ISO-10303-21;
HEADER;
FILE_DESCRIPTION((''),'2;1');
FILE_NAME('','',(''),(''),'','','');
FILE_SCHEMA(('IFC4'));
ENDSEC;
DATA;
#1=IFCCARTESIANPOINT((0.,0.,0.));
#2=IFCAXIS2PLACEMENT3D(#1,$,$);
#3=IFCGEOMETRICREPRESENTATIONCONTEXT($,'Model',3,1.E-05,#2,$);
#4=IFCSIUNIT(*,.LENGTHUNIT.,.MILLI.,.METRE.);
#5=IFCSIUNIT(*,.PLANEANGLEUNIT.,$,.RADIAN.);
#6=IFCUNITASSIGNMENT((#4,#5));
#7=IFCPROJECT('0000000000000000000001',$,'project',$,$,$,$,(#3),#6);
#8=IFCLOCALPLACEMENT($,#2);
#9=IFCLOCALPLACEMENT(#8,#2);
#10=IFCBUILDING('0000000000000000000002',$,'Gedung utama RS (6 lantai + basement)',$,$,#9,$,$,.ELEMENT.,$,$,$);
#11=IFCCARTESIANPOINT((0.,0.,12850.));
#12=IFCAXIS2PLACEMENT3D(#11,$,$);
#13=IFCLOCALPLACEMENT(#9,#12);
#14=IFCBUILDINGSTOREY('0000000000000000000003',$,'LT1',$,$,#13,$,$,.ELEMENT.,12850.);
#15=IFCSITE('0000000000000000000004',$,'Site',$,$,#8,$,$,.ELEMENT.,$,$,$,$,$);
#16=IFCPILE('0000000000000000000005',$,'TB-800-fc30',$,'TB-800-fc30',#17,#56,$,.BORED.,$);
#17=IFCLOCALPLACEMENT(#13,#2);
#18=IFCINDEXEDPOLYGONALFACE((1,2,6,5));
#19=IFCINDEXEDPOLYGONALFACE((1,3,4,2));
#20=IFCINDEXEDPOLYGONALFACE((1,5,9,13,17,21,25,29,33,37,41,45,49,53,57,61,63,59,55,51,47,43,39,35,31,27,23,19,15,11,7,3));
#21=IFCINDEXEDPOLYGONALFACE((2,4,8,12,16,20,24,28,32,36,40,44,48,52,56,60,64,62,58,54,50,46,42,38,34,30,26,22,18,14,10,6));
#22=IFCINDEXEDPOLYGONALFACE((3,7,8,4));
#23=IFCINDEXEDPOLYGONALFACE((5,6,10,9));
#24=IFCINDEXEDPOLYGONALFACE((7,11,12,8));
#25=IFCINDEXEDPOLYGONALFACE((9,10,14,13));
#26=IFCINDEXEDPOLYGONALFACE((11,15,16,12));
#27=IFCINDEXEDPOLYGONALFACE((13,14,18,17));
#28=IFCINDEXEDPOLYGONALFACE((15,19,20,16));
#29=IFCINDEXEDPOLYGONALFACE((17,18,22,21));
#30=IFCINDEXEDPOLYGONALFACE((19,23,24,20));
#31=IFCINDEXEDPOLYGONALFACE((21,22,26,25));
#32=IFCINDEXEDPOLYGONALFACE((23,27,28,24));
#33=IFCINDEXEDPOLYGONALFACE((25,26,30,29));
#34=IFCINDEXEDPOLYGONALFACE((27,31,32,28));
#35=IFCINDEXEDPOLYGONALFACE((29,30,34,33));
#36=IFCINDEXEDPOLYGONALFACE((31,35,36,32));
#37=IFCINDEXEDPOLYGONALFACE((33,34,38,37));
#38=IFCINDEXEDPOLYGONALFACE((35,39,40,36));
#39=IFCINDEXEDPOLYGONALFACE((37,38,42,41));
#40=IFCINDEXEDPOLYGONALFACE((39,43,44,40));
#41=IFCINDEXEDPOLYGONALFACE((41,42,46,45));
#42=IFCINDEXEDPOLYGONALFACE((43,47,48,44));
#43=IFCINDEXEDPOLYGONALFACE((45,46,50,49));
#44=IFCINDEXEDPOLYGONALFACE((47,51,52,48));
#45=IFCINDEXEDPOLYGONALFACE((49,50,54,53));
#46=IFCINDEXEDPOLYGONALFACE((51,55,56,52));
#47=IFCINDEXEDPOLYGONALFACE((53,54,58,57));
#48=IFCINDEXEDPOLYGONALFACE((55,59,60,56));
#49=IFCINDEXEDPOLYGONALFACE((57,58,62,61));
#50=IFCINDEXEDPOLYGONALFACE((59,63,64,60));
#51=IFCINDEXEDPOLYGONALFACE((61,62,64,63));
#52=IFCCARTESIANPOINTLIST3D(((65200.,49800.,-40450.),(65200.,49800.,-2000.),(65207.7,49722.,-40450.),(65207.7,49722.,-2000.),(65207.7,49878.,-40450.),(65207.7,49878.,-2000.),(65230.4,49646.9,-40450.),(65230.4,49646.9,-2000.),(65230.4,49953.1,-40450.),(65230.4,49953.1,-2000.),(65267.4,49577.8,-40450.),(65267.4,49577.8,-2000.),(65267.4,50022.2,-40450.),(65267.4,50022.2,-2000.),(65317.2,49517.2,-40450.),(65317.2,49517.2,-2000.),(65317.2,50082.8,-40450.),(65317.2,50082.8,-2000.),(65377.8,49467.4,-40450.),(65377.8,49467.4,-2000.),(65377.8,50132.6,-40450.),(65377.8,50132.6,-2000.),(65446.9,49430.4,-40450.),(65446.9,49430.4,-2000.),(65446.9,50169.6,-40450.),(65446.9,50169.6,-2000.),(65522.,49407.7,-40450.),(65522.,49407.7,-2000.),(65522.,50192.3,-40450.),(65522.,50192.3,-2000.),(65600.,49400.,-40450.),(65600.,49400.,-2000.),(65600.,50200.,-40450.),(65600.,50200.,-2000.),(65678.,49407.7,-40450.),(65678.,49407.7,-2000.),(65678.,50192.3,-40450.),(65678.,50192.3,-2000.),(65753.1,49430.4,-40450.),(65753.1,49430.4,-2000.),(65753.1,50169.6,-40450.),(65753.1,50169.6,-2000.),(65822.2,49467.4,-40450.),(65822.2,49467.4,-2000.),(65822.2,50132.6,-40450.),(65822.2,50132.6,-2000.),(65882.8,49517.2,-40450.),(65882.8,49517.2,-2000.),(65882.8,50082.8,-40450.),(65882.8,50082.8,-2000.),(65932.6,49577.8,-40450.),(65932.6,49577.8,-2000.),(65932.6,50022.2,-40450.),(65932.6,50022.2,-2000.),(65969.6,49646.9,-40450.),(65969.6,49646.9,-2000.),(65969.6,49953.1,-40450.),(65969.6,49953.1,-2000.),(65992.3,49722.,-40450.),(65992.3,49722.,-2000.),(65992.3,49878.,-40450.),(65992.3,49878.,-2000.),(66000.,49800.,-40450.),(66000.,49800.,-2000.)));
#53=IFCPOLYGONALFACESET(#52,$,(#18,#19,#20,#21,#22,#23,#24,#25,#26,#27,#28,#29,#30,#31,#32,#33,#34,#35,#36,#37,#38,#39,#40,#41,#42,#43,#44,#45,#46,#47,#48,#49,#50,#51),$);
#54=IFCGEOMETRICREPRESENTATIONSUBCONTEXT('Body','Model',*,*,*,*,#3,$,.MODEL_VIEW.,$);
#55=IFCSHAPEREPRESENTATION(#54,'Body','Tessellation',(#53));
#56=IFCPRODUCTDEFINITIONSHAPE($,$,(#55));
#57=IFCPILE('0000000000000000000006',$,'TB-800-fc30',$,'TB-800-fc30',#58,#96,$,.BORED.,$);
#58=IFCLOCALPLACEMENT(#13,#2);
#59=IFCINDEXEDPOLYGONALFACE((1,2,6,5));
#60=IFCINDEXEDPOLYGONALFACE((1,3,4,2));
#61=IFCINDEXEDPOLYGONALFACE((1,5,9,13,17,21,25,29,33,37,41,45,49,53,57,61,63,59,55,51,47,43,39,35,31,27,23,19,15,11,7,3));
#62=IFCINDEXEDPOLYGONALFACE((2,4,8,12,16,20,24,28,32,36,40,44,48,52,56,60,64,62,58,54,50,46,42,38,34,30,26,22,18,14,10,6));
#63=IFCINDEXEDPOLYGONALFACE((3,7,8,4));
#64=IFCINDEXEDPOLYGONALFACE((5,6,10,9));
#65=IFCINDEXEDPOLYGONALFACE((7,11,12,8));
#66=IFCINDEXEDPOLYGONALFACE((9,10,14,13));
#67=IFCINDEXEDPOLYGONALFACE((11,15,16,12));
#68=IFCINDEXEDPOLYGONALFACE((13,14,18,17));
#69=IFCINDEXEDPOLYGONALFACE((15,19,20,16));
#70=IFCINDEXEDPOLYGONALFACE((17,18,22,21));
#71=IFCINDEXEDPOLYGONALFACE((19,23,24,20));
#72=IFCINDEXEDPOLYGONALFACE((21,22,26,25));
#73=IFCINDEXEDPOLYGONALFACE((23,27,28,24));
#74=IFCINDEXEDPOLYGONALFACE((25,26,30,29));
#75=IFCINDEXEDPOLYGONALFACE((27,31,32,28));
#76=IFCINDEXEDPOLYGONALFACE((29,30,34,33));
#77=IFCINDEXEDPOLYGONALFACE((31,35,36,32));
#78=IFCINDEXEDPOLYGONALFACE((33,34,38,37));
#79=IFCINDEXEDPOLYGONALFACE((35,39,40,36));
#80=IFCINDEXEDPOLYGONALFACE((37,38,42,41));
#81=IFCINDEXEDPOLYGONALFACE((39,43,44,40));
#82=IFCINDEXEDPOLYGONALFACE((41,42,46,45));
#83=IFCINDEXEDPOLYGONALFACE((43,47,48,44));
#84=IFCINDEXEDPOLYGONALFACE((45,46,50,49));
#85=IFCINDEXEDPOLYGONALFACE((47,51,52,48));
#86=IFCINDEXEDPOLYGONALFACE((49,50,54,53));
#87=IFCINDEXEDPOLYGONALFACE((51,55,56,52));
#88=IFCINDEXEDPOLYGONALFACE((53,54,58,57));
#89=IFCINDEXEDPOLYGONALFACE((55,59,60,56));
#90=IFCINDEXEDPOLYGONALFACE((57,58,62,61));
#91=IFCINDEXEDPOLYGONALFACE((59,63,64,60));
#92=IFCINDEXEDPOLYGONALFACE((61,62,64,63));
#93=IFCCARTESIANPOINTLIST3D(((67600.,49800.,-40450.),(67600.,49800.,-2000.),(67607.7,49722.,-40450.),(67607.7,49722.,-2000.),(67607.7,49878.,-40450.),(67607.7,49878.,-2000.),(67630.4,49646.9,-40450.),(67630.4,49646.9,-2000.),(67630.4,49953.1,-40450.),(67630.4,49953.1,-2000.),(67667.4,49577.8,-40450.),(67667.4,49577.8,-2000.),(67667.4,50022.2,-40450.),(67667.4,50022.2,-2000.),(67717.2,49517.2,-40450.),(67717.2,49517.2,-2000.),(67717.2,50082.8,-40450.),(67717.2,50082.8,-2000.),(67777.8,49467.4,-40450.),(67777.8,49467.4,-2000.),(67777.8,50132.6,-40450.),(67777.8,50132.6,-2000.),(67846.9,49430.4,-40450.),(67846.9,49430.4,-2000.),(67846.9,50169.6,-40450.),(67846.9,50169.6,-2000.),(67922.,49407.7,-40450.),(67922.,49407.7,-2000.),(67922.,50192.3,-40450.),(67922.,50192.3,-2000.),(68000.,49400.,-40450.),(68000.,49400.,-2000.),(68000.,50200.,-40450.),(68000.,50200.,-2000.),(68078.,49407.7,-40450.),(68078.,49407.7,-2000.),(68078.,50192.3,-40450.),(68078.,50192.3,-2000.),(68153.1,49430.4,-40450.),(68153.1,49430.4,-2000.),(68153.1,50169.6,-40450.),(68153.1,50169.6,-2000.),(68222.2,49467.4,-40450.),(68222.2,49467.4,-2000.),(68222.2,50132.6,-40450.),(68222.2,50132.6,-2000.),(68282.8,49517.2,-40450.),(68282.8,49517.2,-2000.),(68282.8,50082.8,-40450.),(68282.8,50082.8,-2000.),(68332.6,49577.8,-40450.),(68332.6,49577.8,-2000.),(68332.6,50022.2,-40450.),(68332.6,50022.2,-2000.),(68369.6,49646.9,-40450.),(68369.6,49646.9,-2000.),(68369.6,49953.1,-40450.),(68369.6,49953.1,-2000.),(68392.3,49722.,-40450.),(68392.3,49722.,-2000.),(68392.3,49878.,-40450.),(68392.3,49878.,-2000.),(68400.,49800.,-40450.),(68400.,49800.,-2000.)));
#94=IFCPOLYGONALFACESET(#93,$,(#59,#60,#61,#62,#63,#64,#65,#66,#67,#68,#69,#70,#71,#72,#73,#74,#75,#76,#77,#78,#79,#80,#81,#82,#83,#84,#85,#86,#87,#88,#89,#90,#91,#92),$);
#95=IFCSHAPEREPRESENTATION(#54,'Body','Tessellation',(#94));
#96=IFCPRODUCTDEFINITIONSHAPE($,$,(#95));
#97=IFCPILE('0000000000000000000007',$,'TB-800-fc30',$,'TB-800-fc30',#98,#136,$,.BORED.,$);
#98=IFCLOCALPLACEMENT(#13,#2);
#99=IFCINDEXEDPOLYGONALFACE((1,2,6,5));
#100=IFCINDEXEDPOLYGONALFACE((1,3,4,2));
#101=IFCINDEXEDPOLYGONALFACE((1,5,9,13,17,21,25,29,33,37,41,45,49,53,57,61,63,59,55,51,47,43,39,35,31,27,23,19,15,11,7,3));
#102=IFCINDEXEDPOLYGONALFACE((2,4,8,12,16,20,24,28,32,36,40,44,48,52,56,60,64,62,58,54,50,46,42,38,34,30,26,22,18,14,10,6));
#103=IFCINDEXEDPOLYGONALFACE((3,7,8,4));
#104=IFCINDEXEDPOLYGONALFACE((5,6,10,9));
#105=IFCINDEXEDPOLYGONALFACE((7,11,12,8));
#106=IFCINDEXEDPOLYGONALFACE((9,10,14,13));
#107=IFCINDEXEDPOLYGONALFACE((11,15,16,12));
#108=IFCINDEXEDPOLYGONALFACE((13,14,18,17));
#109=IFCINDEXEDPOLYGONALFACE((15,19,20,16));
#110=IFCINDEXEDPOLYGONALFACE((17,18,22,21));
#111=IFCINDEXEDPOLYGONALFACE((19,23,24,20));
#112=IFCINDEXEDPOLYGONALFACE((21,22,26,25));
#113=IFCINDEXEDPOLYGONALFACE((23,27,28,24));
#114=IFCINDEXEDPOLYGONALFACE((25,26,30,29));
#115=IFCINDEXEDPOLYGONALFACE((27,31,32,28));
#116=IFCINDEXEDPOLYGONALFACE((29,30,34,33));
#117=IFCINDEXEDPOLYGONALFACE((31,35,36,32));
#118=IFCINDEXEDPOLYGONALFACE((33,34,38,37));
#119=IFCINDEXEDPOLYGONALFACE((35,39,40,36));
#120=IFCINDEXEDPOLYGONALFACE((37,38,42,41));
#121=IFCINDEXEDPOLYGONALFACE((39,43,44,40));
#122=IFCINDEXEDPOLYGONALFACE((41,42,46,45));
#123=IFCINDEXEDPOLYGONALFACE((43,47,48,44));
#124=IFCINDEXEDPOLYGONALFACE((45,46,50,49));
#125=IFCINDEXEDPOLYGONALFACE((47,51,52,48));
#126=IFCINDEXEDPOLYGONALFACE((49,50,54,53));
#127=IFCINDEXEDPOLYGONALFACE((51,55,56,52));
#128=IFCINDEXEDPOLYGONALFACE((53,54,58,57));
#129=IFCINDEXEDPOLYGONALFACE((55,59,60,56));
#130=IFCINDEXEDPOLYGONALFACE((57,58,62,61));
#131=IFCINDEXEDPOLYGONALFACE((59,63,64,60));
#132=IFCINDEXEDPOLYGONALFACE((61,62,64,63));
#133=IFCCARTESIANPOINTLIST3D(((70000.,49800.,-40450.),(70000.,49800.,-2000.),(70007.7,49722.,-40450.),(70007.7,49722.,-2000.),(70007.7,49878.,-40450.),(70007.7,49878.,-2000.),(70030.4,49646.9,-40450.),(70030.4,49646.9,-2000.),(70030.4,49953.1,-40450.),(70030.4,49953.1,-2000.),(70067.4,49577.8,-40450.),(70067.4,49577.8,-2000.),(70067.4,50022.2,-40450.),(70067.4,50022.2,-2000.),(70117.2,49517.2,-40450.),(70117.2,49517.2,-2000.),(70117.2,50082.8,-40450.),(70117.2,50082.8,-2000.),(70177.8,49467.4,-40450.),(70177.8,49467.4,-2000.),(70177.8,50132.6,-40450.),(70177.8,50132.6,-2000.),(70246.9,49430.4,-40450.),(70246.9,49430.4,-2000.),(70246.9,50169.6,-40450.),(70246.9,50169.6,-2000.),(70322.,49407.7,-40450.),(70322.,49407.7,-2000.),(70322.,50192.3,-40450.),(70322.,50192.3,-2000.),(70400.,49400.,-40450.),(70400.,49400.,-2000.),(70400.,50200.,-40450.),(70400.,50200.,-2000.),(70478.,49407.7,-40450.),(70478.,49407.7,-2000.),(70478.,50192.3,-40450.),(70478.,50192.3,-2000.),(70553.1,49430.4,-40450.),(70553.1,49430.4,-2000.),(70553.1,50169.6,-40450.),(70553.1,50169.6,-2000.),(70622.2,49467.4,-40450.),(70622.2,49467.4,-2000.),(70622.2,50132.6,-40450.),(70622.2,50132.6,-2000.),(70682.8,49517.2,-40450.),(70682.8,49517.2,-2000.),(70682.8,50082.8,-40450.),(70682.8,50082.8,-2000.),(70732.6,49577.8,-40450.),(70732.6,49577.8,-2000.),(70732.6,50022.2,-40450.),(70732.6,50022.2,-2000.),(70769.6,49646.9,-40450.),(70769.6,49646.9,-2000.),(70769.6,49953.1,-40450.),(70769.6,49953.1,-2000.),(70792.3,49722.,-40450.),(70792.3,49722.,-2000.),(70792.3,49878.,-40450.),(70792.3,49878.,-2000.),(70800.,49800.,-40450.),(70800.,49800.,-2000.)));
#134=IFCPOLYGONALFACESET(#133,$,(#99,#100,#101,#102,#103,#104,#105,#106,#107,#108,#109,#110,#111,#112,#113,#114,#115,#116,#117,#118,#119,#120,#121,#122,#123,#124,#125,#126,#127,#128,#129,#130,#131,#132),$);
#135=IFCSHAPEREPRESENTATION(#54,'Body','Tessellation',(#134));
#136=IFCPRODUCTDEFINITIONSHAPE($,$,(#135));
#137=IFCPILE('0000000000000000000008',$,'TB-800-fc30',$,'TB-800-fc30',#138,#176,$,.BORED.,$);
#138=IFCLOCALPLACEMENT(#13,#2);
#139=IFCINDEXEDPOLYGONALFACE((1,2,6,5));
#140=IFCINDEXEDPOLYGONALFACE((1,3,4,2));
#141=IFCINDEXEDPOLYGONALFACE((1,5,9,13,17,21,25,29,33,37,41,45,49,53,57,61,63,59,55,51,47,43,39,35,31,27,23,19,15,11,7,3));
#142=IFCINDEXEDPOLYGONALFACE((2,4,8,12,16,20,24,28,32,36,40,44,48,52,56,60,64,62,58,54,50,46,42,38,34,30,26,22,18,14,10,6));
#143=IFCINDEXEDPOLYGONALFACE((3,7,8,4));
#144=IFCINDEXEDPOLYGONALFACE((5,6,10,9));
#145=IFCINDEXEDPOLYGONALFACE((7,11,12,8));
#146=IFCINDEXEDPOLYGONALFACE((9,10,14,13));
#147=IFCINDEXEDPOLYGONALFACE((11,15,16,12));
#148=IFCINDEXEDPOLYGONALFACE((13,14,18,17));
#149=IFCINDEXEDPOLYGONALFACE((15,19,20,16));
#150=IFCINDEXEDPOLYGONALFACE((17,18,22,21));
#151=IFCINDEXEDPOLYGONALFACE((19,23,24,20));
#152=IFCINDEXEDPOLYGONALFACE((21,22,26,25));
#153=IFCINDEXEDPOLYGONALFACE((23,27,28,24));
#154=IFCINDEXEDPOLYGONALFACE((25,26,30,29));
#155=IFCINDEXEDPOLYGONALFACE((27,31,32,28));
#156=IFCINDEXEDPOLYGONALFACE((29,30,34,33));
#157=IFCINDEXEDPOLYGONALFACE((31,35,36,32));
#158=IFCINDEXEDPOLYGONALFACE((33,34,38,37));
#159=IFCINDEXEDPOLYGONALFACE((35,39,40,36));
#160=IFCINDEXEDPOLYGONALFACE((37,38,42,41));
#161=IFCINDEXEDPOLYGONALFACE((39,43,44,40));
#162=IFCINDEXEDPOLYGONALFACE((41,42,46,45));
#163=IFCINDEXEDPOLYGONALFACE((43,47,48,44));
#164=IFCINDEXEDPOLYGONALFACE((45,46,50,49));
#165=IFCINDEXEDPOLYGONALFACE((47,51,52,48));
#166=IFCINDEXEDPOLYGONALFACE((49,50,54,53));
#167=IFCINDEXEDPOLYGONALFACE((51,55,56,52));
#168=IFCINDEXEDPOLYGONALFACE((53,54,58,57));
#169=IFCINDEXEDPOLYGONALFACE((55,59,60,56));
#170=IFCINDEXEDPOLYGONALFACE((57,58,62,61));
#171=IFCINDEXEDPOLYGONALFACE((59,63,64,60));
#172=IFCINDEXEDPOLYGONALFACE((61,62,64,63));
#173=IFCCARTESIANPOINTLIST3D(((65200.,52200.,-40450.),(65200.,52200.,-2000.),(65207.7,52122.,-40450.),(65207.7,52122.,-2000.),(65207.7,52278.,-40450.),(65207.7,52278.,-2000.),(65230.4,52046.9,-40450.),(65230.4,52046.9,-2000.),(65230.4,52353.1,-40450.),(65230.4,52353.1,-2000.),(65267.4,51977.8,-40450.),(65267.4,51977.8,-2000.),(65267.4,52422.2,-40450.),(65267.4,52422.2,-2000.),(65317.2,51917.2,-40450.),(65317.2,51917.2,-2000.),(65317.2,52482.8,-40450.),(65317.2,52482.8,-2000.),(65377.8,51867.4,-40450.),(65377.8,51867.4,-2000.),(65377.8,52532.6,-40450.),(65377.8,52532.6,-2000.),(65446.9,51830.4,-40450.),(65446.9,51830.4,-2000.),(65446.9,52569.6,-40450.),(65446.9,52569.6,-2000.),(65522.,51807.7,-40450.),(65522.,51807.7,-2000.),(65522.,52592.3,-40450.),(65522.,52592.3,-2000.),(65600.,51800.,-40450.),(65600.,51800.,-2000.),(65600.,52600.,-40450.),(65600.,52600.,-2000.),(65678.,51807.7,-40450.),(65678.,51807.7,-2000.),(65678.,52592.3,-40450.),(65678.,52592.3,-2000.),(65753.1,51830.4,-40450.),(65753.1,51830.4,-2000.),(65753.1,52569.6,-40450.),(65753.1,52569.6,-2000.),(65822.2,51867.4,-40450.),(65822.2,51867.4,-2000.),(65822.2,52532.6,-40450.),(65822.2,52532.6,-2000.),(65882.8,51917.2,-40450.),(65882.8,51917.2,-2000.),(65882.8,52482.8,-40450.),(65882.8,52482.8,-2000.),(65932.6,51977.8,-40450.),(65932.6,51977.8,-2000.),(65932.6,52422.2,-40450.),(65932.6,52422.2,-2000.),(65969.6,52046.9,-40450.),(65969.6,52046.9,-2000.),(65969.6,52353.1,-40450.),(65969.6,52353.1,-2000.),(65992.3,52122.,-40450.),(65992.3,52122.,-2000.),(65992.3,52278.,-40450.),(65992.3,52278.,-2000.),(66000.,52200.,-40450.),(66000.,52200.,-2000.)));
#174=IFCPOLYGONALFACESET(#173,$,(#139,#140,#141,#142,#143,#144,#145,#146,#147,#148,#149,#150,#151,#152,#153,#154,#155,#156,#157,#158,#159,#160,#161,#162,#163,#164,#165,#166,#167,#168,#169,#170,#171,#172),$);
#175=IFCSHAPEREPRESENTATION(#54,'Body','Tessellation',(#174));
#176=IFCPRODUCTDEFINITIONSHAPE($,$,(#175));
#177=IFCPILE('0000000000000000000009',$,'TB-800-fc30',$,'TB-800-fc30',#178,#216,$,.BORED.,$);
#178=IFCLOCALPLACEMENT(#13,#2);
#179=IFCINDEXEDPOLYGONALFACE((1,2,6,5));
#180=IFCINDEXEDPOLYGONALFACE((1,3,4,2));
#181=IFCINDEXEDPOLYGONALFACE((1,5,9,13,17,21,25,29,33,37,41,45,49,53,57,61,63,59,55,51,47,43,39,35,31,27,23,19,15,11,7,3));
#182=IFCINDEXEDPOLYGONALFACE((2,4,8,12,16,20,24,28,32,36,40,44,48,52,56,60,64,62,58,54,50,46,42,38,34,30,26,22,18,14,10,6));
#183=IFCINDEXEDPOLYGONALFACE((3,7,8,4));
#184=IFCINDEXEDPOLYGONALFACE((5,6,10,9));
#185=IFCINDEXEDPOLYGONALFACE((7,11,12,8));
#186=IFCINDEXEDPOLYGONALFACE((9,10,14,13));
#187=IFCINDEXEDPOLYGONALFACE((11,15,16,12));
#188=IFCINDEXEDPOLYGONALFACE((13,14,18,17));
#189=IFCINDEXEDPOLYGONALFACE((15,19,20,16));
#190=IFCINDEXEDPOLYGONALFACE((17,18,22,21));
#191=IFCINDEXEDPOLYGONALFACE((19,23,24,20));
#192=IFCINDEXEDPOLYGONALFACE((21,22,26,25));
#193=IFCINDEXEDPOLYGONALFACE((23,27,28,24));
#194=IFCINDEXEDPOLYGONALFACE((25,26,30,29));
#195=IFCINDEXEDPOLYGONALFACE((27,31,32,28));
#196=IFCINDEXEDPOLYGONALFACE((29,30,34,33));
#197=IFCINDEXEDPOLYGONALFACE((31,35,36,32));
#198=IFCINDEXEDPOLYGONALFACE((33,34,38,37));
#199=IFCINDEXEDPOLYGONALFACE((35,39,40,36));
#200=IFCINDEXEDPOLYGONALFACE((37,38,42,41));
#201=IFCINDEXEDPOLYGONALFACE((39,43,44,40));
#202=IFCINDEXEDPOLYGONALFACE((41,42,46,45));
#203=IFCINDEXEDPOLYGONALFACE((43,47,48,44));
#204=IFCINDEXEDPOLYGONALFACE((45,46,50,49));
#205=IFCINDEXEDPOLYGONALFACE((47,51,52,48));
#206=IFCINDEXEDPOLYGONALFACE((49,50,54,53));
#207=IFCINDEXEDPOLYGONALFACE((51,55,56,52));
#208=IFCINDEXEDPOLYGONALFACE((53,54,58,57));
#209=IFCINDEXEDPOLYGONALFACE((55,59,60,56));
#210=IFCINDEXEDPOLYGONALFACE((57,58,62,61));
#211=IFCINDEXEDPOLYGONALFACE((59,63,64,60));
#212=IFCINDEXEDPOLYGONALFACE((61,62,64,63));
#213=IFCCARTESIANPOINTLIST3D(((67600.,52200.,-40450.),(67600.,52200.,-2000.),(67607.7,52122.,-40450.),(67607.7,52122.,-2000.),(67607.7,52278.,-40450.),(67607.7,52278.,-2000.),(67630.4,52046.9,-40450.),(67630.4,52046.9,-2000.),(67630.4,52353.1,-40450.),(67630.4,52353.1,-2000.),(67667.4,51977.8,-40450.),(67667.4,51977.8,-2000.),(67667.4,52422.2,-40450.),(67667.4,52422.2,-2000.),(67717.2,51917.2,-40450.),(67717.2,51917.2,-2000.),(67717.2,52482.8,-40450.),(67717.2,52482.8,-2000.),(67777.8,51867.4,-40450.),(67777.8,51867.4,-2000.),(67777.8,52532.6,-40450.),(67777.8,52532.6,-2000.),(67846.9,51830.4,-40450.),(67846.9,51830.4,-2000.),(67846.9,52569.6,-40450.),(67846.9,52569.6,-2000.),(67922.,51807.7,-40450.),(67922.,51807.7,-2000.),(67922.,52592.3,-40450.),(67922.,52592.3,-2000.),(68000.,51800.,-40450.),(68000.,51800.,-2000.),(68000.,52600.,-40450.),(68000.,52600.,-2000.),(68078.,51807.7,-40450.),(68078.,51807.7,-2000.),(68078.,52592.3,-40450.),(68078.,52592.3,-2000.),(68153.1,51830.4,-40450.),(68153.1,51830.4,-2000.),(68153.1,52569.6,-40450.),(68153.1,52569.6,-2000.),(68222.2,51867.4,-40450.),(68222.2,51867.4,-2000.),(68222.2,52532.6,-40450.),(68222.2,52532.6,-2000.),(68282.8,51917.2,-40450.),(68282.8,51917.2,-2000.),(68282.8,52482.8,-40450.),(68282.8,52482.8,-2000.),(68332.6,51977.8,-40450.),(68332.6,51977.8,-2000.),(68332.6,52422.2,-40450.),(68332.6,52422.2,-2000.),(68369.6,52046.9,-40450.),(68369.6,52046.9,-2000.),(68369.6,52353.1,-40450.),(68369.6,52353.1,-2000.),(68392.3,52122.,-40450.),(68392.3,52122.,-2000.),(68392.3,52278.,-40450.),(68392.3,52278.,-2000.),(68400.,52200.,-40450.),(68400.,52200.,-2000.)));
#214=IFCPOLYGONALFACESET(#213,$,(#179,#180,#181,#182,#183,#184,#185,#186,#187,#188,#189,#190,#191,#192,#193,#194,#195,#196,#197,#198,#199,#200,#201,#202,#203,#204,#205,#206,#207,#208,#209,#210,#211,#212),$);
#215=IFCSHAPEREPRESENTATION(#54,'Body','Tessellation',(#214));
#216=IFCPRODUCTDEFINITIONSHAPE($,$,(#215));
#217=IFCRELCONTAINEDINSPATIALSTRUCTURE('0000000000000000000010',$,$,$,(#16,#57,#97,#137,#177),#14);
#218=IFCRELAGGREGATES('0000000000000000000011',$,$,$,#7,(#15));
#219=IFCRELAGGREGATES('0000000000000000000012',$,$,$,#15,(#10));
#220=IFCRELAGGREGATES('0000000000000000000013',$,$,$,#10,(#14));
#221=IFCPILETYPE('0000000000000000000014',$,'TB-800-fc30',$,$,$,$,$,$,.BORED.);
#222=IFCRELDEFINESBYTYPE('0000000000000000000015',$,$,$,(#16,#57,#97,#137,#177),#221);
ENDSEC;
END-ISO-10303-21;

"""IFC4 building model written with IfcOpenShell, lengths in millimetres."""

from ifc_helpers import new_model, si_unit, frame, origin, origin_2d, place, context, subcontext, project, spatial, circle, extrude, material_profile, profile_set, profile_usage, type_object, element, save


model = new_model("IFC4")

# Units and contexts
model_context = context("Model", 3, precision=1e-05, world=origin())
body_context = subcontext(model_context, "Body", "Model", "MODEL_VIEW")
ifc_project = project(units=[si_unit("LENGTHUNIT", "METRE", prefix="MILLI"), si_unit("PLANEANGLEUNIT", "RADIAN")], contexts=[model_context])

# Site, building, storey
site_placement = place(None, origin())
site = spatial("IfcSite", under=ifc_project, at=site_placement, Name="Site", CompositionType="ELEMENT")
building_placement = place(site_placement, origin())
building = spatial("IfcBuilding", under=site, at=building_placement, Name="Gedung utama RS (6 lantai + basement)", CompositionType="ELEMENT")
storey_placement = place(building_placement, frame((0.0, 0.0, 12850.0)))
storey = spatial("IfcBuildingStorey", under=building, at=storey_placement, Name="LT1", CompositionType="ELEMENT", Elevation=12850.0)

# Piles
ifc_material_profile = material_profile(None, circle(Radius=400.0, at=origin_2d()), Name="TB-800-fc30")
ifc_profile_set = profile_set([ifc_material_profile], Name="TB-800-fc30")
ifc_profile_usage = profile_usage(ifc_profile_set, cardinal=5)
pile_type = type_object("IfcPileType", Name="TB-800-fc30", PredefinedType="BORED", material=ifc_profile_set)
for number, where, z_axis, x_axis, name in (
    (1, (65600.0, 49800.0, -40450.0), (0.0, 0.0, 1.0), (1.0, 0.0, 0.0), "TB-800-fc30"),
    (2, (68000.0, 49800.0, -40450.0), (0.0, 0.0, 1.0), (1.0, 0.0, 0.0), "TB-800-fc30"),
    (3, (70400.0, 49800.0, -40450.0), (0.0, 0.0, 1.0), (1.0, 0.0, 0.0), "TB-800-fc30"),
    (4, (65600.0, 52200.0, -40450.0), (0.0, 0.0, 1.0), (1.0, 0.0, 0.0), "TB-800-fc30"),
    (5, (68000.0, 52200.0, -40450.0), (0.0, 0.0, 1.0), (1.0, 0.0, 0.0), "TB-800-fc30"),
):
    element("IfcPile", number, at=place(storey_placement, frame(where, z_axis=z_axis, x_axis=x_axis)), inside=storey, type_object=pile_type, material=ifc_profile_usage, Name=name, ObjectType="TB-800-fc30", PredefinedType="BORED", context=body_context, shape_type="SweptSolid", body=[
        extrude(circle(Radius=400.0, at=origin_2d()), origin(), (0.0, 0.0, 1.0), 38450.0),
    ])

save(model, "model.ifc")
